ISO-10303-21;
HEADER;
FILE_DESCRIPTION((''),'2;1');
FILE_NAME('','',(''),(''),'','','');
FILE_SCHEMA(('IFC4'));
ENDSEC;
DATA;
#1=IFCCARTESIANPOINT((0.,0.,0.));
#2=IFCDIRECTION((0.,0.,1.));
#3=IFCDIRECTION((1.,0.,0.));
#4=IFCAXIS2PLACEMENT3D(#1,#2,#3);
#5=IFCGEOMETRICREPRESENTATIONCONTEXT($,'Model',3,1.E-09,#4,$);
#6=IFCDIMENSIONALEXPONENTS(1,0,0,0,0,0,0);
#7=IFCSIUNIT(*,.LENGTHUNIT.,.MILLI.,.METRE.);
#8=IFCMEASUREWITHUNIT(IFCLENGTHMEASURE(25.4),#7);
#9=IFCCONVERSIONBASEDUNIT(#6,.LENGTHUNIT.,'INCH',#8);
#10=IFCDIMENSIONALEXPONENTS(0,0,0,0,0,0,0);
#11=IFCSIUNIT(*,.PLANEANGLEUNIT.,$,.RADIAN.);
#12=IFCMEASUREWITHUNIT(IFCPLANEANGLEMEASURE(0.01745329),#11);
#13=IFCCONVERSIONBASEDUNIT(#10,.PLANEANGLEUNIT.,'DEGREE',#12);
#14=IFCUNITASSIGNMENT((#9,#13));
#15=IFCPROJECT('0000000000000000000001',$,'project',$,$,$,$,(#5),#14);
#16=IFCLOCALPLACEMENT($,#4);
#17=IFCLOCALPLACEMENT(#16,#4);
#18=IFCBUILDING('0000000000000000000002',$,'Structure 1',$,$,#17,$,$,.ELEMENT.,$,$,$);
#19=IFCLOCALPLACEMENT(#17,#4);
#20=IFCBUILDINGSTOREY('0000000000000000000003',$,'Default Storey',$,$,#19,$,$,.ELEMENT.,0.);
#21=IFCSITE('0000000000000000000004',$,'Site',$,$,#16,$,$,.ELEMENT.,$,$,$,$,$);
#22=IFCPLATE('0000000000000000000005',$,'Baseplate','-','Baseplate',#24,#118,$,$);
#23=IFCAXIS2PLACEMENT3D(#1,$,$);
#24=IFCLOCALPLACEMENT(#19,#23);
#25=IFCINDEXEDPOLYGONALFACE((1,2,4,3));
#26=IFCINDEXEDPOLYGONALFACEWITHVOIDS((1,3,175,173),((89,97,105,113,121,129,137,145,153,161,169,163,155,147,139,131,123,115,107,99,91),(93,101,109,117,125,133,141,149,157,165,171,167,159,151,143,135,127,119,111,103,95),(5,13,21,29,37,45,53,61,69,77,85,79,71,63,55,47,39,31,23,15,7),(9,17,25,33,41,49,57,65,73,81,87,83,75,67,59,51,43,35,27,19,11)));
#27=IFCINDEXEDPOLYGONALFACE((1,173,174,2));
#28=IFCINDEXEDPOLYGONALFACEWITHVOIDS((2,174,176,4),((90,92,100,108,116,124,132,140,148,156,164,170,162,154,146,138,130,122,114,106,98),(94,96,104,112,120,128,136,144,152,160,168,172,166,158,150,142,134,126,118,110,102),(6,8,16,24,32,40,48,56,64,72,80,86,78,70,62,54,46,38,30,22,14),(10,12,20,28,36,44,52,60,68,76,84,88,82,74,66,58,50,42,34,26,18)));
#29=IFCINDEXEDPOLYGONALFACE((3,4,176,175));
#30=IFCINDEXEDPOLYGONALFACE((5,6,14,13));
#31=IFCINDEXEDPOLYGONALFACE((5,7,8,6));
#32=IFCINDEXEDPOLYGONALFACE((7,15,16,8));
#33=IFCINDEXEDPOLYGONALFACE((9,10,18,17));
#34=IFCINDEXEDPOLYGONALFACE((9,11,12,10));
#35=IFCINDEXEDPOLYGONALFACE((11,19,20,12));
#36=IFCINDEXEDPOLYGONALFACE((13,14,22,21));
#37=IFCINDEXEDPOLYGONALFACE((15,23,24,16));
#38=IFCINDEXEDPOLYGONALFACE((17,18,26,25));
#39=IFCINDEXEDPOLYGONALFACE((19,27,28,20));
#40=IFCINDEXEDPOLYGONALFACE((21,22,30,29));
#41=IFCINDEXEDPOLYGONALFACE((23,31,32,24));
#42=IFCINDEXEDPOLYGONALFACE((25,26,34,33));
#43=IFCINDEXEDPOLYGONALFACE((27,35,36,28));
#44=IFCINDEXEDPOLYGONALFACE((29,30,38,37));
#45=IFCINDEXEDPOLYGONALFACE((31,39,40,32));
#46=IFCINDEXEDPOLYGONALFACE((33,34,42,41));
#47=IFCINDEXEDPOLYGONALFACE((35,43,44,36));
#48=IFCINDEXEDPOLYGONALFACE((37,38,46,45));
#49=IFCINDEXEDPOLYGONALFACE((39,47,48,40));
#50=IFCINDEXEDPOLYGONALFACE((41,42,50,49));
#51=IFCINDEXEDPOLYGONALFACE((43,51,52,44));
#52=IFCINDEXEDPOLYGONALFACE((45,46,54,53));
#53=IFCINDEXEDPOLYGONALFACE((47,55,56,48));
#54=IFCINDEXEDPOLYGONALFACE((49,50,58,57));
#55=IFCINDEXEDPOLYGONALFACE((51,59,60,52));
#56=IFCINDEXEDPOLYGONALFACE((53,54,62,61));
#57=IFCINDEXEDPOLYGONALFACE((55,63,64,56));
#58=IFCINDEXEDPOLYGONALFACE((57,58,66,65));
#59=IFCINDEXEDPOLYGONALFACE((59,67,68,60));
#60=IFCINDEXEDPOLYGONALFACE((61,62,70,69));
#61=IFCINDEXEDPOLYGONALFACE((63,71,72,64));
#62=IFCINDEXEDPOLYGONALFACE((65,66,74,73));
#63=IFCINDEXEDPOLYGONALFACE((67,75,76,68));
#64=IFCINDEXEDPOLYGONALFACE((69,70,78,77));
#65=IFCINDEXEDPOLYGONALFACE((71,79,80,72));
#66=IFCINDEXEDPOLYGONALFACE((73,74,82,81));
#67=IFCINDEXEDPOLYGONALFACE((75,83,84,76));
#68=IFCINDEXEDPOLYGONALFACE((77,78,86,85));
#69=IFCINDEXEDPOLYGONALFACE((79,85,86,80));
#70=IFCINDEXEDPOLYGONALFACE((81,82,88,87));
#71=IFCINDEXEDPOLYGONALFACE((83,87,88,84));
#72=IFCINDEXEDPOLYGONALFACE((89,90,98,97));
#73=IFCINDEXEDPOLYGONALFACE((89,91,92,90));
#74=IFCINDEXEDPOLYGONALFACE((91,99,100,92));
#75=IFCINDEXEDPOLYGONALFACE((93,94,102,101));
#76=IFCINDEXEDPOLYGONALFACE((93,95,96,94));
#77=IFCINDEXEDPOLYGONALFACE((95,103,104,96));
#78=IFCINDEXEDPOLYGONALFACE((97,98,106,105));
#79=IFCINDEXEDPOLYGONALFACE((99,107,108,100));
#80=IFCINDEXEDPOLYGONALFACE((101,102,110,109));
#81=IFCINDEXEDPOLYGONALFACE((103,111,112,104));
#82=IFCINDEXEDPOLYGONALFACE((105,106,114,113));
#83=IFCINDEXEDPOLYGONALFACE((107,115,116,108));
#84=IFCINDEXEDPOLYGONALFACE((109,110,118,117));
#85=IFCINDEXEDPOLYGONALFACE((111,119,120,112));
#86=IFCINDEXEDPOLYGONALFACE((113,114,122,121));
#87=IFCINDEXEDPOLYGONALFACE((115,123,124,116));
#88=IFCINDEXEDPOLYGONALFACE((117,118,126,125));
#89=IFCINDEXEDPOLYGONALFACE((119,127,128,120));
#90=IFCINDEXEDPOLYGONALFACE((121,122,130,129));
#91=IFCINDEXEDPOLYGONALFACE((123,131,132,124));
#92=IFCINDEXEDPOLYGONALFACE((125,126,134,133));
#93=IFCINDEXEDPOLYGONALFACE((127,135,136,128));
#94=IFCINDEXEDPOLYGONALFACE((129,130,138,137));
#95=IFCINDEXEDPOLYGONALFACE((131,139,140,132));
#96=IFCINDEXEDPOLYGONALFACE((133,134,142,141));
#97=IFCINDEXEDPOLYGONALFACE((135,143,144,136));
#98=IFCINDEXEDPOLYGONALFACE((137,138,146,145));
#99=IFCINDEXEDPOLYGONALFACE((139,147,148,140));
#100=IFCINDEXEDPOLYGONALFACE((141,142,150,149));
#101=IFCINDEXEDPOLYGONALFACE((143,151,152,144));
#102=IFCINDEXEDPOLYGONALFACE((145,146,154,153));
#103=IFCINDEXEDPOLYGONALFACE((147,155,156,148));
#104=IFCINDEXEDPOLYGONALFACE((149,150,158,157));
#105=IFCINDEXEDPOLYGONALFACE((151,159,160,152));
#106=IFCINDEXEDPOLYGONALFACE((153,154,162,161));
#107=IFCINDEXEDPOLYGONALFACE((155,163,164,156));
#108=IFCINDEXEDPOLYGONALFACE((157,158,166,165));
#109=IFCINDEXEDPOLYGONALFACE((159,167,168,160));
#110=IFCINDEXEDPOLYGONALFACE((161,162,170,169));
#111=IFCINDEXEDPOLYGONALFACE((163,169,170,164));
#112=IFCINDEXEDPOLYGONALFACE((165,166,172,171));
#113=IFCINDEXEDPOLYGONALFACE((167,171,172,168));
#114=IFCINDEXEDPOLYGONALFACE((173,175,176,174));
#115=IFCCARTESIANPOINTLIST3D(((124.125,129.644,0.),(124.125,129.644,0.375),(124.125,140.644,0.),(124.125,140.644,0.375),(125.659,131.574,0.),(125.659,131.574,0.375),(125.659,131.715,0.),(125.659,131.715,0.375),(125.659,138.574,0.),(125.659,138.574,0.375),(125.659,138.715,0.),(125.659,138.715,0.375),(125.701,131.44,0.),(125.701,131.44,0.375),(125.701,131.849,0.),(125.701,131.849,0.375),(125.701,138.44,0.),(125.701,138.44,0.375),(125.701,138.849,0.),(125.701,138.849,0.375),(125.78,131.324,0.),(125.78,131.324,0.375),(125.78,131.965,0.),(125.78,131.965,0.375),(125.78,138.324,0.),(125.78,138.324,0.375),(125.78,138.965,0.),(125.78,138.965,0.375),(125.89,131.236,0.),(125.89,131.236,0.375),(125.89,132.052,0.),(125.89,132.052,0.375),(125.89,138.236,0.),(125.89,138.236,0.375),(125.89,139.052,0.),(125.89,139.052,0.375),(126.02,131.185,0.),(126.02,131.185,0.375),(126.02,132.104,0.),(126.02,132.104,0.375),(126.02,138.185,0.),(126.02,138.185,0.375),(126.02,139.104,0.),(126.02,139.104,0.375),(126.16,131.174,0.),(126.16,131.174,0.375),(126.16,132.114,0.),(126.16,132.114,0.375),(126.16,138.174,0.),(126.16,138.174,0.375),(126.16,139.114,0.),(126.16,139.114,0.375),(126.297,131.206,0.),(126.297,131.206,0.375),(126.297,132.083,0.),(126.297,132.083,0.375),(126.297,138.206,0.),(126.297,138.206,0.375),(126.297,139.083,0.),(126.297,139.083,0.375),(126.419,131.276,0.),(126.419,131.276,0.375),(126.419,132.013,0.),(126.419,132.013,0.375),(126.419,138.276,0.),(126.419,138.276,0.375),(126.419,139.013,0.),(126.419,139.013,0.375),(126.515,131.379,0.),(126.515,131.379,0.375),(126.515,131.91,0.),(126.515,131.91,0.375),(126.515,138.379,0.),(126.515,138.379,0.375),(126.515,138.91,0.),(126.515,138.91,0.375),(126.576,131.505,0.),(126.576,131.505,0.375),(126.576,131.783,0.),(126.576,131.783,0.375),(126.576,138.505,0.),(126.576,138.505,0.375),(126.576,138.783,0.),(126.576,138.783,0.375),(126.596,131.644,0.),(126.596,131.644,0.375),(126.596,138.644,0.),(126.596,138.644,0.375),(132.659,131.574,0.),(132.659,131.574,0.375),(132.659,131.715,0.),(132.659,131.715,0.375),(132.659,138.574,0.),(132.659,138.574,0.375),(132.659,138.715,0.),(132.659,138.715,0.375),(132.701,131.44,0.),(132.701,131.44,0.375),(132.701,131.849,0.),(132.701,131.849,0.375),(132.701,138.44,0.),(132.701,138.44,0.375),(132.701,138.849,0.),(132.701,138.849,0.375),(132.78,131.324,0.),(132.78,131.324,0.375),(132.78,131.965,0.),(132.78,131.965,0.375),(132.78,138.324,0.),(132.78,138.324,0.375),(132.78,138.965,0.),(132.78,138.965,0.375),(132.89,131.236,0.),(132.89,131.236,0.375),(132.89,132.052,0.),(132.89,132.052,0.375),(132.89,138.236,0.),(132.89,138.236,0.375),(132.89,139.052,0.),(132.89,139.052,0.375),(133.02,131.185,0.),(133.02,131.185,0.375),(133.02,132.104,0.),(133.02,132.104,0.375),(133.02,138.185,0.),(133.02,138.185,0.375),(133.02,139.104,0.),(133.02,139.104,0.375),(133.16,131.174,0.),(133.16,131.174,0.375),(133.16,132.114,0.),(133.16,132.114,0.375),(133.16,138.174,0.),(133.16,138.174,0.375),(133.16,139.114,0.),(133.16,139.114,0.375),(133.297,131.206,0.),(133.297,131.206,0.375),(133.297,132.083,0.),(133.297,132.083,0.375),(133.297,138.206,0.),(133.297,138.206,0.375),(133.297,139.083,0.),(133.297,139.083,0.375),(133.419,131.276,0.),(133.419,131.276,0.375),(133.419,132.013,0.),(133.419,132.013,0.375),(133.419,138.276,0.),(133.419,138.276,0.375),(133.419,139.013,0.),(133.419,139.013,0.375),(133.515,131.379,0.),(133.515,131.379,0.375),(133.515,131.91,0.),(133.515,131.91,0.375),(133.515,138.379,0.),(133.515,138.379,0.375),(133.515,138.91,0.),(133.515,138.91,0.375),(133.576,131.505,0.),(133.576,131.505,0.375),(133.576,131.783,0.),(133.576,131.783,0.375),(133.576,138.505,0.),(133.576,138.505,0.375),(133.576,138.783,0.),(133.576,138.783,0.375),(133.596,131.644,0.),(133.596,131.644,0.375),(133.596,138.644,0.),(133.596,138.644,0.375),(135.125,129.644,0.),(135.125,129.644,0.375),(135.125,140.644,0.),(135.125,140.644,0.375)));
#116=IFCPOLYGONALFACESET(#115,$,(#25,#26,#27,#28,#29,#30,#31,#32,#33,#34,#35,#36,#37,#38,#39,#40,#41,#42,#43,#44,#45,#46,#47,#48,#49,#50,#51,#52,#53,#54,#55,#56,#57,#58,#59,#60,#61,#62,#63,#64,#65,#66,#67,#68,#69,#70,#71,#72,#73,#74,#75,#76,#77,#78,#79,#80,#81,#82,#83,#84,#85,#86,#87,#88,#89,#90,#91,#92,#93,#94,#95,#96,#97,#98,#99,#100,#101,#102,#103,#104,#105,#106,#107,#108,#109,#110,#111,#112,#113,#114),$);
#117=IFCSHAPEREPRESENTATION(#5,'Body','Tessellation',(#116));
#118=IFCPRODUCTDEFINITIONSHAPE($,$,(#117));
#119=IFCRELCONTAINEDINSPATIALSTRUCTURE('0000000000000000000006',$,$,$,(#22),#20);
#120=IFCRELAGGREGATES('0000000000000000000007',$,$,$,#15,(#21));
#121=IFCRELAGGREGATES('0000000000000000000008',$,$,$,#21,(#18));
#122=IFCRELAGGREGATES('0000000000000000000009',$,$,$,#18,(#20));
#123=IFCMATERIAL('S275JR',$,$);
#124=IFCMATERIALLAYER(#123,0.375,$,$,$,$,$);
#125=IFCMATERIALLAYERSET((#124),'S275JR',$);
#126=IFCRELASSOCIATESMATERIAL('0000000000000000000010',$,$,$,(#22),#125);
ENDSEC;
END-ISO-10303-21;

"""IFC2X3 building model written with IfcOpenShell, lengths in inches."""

from ifc_helpers import new_model, entity, si_unit, converted_unit, frame, frame_2d, origin, origin_with_axes, origin_2d_with_axis, place, context, project, spatial, polyline, circle, outline, extrude, material, layer, layer_set, element, save


model = new_model("IFC2X3")

# Units and contexts
model_context = context("Model", 3, precision=1e-09, world=origin_with_axes())
ifc_project = project(units=[converted_unit("LENGTHUNIT", "INCH", entity("IfcLengthMeasure", 25.4), si_unit("LENGTHUNIT", "METRE", prefix="MILLI"), dimensions=[1, 0, 0, 0, 0, 0, 0]), converted_unit("PLANEANGLEUNIT", "DEGREE", entity("IfcPlaneAngleMeasure", 0.01745329), si_unit("PLANEANGLEUNIT", "RADIAN"), dimensions=[0, 0, 0, 0, 0, 0, 0])], contexts=[model_context])

# Site, building, storey
site_placement = place(None, origin_with_axes())
site = spatial("IfcSite", under=ifc_project, at=site_placement, Name="Site", CompositionType="ELEMENT")
building_placement = place(site_placement, origin_with_axes())
building = spatial("IfcBuilding", under=site, at=building_placement, Name="Structure 1", CompositionType="ELEMENT")
storey_placement = place(building_placement, origin_with_axes())
storey = spatial("IfcBuildingStorey", under=building, at=storey_placement, Name="Default Storey", CompositionType="ELEMENT", Elevation=0.0)

# Plate, openings
ifc_material_1 = material(Name="S275JR")
ifc_layer_1 = layer(ifc_material_1, 0.375)
ifc_layer_set_1 = layer_set([ifc_layer_1], Name="S275JR")
plate_1_placement = place(None, frame((135.125, 140.644, 0.375), z_axis=(0.0, 0.0, -1.0), x_axis=(0.0, -1.0, 0.0)))
plate_1 = element("IfcPlate", 1, at=plate_1_placement, inside=storey, material=ifc_layer_set_1, Name="Baseplate", Description="-", ObjectType="Baseplate", context=model_context, shape_type="SweptSolid", body=[
    extrude(outline(polyline([(0.0, 0.0), (11.0, 0.0), (11.0, 11.0), (0.0, 11.0), (0.0, 0.0)])), origin_with_axes(), (0.0, 0.0, 1.0), 0.375),
])
opening_1_placement = place(plate_1_placement, frame((2.0, 9.0, 0.395), z_axis=(0.0, 0.0, -1.0), x_axis=(1.0, 0.0, 0.0)))
element("IfcOpeningElement", 2, at=opening_1_placement, cuts=plate_1, ObjectType="Opening", context=model_context, shape_type="SweptSolid", body=[
    extrude(circle(Radius=0.433, at=frame_2d((7.0, 7.0), x_axis=(1.0, 0.0))), origin(), (0.0, 0.0, 1.0), 0.414),
])
opening_2_placement = place(plate_1_placement, frame((2.0, 9.0, 0.395), z_axis=(0.0, 0.0, -1.0), x_axis=(1.0, 0.0, 0.0)))
element("IfcOpeningElement", 3, at=opening_2_placement, cuts=plate_1, ObjectType="Opening", context=model_context, shape_type="SweptSolid", body=[
    extrude(circle(Radius=0.433, at=frame_2d((0.0, 7.0), x_axis=(1.0, 0.0))), origin(), (0.0, 0.0, 1.0), 0.414),
])
opening_3_placement = place(plate_1_placement, frame((2.0, 9.0, 0.395), z_axis=(0.0, 0.0, -1.0), x_axis=(1.0, 0.0, 0.0)))
element("IfcOpeningElement", 4, at=opening_3_placement, cuts=plate_1, ObjectType="Opening", context=model_context, shape_type="SweptSolid", body=[
    extrude(circle(Radius=0.433, at=frame_2d((7.0, 0.0), x_axis=(1.0, 0.0))), origin(), (0.0, 0.0, 1.0), 0.414),
])
opening_4_placement = place(plate_1_placement, frame((2.0, 9.0, 0.395), z_axis=(0.0, 0.0, -1.0), x_axis=(1.0, 0.0, 0.0)))
element("IfcOpeningElement", 5, at=opening_4_placement, cuts=plate_1, ObjectType="Opening", context=model_context, shape_type="SweptSolid", body=[
    extrude(circle(Radius=0.433, at=origin_2d_with_axis()), origin(), (0.0, 0.0, 1.0), 0.414),
])
opening_5_placement = place(plate_1_placement, frame((2.0, 9.0, 0.395), z_axis=(0.0, 0.0, -1.0), x_axis=(0.0, -1.0, 0.0)))
element("IfcOpeningElement", 6, at=opening_5_placement, cuts=plate_1, ObjectType="Opening", context=model_context, shape_type="SweptSolid", body=[
    extrude(circle(Radius=0.471, at=origin_2d_with_axis()), origin(), (0.0, 0.0, 1.0), 0.414),
])
opening_6_placement = place(plate_1_placement, frame((9.0, 2.0, 0.395), z_axis=(0.0, 0.0, -1.0), x_axis=(0.0, -1.0, 0.0)))
element("IfcOpeningElement", 7, at=opening_6_placement, cuts=plate_1, ObjectType="Opening", context=model_context, shape_type="SweptSolid", body=[
    extrude(circle(Radius=0.471, at=origin_2d_with_axis()), origin(), (0.0, 0.0, 1.0), 0.414),
])
opening_7_placement = place(plate_1_placement, frame((9.0, 9.0, 0.395), z_axis=(0.0, 0.0, -1.0), x_axis=(0.0, -1.0, 0.0)))
element("IfcOpeningElement", 8, at=opening_7_placement, cuts=plate_1, ObjectType="Opening", context=model_context, shape_type="SweptSolid", body=[
    extrude(circle(Radius=0.471, at=origin_2d_with_axis()), origin(), (0.0, 0.0, 1.0), 0.414),
])
opening_8_placement = place(plate_1_placement, frame((2.0, 2.0, 0.395), z_axis=(0.0, 0.0, -1.0), x_axis=(0.0, -1.0, 0.0)))
element("IfcOpeningElement", 9, at=opening_8_placement, cuts=plate_1, ObjectType="Opening", context=model_context, shape_type="SweptSolid", body=[
    extrude(circle(Radius=0.471, at=origin_2d_with_axis()), origin(), (0.0, 0.0, 1.0), 0.414),
])

save(model, "model.ifc")
